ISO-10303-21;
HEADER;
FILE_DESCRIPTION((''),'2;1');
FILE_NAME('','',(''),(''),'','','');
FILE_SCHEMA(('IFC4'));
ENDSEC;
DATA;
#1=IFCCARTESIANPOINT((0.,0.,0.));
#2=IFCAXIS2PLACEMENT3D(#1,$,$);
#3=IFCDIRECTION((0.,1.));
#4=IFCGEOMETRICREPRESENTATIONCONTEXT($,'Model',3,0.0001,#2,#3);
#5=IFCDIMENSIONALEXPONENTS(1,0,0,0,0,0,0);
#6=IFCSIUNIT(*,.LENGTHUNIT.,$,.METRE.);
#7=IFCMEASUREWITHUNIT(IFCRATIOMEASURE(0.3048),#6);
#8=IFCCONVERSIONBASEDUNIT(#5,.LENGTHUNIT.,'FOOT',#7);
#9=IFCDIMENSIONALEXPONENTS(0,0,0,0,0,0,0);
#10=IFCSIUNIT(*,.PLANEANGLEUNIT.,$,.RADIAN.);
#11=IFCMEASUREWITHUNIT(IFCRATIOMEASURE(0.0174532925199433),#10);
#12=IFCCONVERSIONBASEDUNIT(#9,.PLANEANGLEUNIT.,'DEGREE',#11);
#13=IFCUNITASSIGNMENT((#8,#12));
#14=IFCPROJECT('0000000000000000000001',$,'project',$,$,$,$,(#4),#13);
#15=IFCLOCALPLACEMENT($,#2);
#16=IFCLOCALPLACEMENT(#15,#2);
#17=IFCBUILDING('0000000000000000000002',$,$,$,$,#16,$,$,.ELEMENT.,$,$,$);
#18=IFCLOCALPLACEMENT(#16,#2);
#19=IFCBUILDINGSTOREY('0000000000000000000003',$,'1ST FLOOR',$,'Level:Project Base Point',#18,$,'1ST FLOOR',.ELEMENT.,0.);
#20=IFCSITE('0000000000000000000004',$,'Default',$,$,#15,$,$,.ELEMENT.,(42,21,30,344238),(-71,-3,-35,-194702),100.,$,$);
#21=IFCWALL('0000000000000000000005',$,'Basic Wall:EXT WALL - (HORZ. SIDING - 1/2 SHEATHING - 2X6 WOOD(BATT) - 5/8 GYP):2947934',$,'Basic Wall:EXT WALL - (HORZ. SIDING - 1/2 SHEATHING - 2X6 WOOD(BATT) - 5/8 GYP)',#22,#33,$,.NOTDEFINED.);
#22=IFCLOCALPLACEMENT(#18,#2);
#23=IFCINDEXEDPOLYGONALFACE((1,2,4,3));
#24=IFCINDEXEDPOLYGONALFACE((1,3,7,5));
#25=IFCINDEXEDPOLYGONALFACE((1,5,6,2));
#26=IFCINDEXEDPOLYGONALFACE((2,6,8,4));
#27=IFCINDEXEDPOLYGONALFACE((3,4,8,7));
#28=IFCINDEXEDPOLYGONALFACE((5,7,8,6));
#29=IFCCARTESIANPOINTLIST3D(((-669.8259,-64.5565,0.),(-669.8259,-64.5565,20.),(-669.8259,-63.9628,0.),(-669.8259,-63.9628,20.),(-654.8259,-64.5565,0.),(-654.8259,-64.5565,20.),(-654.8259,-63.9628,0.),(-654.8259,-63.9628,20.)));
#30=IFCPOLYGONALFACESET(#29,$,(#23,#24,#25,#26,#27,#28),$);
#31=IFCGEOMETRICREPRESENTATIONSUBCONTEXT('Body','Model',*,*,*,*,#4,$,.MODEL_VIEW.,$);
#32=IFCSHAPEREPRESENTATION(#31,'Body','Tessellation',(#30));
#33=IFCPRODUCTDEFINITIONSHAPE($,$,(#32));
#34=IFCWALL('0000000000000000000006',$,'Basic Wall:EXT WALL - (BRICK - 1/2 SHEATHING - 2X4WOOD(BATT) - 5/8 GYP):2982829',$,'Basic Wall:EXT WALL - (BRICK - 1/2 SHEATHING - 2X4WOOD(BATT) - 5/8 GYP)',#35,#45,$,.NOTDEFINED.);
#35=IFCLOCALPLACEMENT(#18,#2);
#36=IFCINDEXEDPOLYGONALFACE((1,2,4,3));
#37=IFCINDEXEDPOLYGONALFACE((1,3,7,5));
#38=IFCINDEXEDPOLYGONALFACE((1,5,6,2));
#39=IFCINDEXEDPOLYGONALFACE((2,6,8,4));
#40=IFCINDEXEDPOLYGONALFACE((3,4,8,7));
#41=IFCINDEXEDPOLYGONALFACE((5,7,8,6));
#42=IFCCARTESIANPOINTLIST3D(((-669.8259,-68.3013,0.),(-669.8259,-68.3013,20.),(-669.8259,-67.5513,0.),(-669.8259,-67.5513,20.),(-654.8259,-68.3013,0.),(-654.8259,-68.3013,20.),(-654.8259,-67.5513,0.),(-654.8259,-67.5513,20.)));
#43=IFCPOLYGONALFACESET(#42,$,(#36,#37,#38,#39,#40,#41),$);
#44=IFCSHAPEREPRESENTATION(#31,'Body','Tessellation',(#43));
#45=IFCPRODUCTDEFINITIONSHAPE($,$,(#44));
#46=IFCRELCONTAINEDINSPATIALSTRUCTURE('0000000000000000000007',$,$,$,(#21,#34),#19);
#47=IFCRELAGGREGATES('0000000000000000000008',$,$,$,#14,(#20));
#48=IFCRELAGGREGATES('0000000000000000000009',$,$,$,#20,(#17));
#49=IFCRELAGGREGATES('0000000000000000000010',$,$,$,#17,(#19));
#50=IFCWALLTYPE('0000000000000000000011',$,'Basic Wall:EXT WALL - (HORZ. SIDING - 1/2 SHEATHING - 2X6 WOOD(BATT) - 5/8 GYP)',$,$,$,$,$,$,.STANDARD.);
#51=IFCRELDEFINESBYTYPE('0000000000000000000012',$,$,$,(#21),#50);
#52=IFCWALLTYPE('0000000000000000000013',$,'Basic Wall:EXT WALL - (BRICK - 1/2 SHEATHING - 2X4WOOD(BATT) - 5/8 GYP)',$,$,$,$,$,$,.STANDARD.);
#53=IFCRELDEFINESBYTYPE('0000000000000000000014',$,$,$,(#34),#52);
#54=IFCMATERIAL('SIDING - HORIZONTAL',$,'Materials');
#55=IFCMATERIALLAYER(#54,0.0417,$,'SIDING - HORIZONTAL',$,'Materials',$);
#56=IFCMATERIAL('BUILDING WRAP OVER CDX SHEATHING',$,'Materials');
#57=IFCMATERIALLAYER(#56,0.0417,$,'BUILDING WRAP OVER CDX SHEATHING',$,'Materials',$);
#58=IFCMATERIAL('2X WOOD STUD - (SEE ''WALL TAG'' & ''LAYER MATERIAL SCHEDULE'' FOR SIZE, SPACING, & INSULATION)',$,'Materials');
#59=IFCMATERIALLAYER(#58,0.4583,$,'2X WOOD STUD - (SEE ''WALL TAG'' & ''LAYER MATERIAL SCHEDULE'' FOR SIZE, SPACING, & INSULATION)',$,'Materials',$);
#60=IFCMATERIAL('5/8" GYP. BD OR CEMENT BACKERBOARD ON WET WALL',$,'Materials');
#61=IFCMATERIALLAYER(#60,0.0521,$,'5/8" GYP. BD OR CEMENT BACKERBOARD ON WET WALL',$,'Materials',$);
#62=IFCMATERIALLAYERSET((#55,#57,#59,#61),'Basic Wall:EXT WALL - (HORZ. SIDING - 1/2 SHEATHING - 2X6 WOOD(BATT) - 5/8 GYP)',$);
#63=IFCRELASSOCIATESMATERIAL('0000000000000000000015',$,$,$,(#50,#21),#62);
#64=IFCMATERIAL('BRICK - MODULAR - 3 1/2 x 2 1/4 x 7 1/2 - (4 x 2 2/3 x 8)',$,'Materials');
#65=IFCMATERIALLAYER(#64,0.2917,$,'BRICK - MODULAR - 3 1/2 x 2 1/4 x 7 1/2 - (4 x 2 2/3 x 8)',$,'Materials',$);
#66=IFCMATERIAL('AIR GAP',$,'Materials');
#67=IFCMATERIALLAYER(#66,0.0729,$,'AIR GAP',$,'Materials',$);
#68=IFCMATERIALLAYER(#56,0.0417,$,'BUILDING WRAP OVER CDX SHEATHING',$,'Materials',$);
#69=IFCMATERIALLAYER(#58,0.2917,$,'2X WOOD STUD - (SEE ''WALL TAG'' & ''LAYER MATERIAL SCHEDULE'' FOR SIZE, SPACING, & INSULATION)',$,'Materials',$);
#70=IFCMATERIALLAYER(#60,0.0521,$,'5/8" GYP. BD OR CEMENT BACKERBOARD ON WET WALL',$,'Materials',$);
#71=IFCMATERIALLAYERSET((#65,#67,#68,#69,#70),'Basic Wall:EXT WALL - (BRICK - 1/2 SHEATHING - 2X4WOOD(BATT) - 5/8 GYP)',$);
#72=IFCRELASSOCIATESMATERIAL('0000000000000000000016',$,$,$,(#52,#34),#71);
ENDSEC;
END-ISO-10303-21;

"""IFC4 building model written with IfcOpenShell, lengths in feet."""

from ifc_helpers import new_model, entity, si_unit, converted_unit, direction, frame, frame_2d, origin, place, context, subcontext, project, spatial, rectangle, extrude, material, layer, layer_set, layer_usage, type_object, element, save


model = new_model("IFC4")

# Units and contexts
model_context = context("Model", 3, precision=0.0001, world=origin(), true_north=direction((0.0, 1.0)))
body_context = subcontext(model_context, "Body", "Model", "MODEL_VIEW")
ifc_project = project(units=[converted_unit("LENGTHUNIT", "FOOT", entity("IfcRatioMeasure", 0.3048), si_unit("LENGTHUNIT", "METRE"), dimensions=[1, 0, 0, 0, 0, 0, 0]), converted_unit("PLANEANGLEUNIT", "DEGREE", entity("IfcRatioMeasure", 0.0174532925199433), si_unit("PLANEANGLEUNIT", "RADIAN"), dimensions=[0, 0, 0, 0, 0, 0, 0])], contexts=[model_context])

# Site, building, storey
site_placement = place(None, origin())
site = spatial("IfcSite", under=ifc_project, at=site_placement, Name="Default", CompositionType="ELEMENT", RefLatitude=(42, 21, 30, 344238), RefLongitude=(-71, -3, -35, -194702), RefElevation=100.0)
building_placement = place(site_placement, origin())
building = spatial("IfcBuilding", under=site, at=building_placement, CompositionType="ELEMENT")
storey_placement = place(building_placement, origin())
storey = spatial("IfcBuildingStorey", under=building, at=storey_placement, Name="1ST FLOOR", ObjectType="Level:Project Base Point", LongName="1ST FLOOR", CompositionType="ELEMENT", Elevation=0.0)

# Walls
ifc_material_1 = material(Name="SIDING - HORIZONTAL", Category="Materials")
ifc_material_2 = material(Name="BUILDING WRAP OVER CDX SHEATHING", Category="Materials")
ifc_material_3 = material(Name="2X WOOD STUD - (SEE 'WALL TAG' & 'LAYER MATERIAL SCHEDULE' FOR SIZE, SPACING, & INSULATION)", Category="Materials")
ifc_material_4 = material(Name="5/8\" GYP. BD OR CEMENT BACKERBOARD ON WET WALL", Category="Materials")
ifc_layer_1 = layer(ifc_material_1, 0.0417, Name="SIDING - HORIZONTAL", Category="Materials")
ifc_layer_2 = layer(ifc_material_2, 0.0417, Name="BUILDING WRAP OVER CDX SHEATHING", Category="Materials")
ifc_layer_3 = layer(ifc_material_3, 0.4583, Name="2X WOOD STUD - (SEE 'WALL TAG' & 'LAYER MATERIAL SCHEDULE' FOR SIZE, SPACING, & INSULATION)", Category="Materials")
ifc_layer_4 = layer(ifc_material_4, 0.0521, Name="5/8\" GYP. BD OR CEMENT BACKERBOARD ON WET WALL", Category="Materials")
ifc_layer_set_1 = layer_set([ifc_layer_1, ifc_layer_2, ifc_layer_3, ifc_layer_4], Name="Basic Wall:EXT WALL - (HORZ. SIDING - 1/2 SHEATHING - 2X6 WOOD(BATT) - 5/8 GYP)")
ifc_layer_usage_1 = layer_usage(ifc_layer_set_1, "AXIS2", "NEGATIVE", 0.2969)
wall_type_1 = type_object("IfcWallType", Name="Basic Wall:EXT WALL - (HORZ. SIDING - 1/2 SHEATHING - 2X6 WOOD(BATT) - 5/8 GYP)", PredefinedType="STANDARD", material=ifc_layer_set_1)
wall_1_placement = place(storey_placement, frame((-669.8259, -64.2596, 0.0)))
element("IfcWall", 1, at=wall_1_placement, inside=storey, type_object=wall_type_1, material=ifc_layer_usage_1, Name="Basic Wall:EXT WALL - (HORZ. SIDING - 1/2 SHEATHING - 2X6 WOOD(BATT) - 5/8 GYP):2947934", ObjectType="Basic Wall:EXT WALL - (HORZ. SIDING - 1/2 SHEATHING - 2X6 WOOD(BATT) - 5/8 GYP)", PredefinedType="NOTDEFINED", context=body_context, shape_type="SweptSolid", body=[
    extrude(rectangle(XDim=15.0, YDim=0.5938, at=frame_2d((7.5, 0.0), x_axis=(-1.0, 0.0))), origin(), (0.0, 0.0, 1.0), 20.0),
])
ifc_material_5 = material(Name="BRICK - MODULAR - 3 1/2 x 2 1/4 x 7 1/2 - (4 x 2 2/3 x 8)", Category="Materials")
ifc_layer_5 = layer(ifc_material_5, 0.2917, Name="BRICK - MODULAR - 3 1/2 x 2 1/4 x 7 1/2 - (4 x 2 2/3 x 8)", Category="Materials")
ifc_material_6 = material(Name="AIR GAP", Category="Materials")
ifc_layer_6 = layer(ifc_material_6, 0.0729, Name="AIR GAP", Category="Materials")
ifc_layer_7 = layer(ifc_material_2, 0.0417, Name="BUILDING WRAP OVER CDX SHEATHING", Category="Materials")
ifc_layer_8 = layer(ifc_material_3, 0.2917, Name="2X WOOD STUD - (SEE 'WALL TAG' & 'LAYER MATERIAL SCHEDULE' FOR SIZE, SPACING, & INSULATION)", Category="Materials")
ifc_layer_9 = layer(ifc_material_4, 0.0521, Name="5/8\" GYP. BD OR CEMENT BACKERBOARD ON WET WALL", Category="Materials")
ifc_layer_set_2 = layer_set([ifc_layer_5, ifc_layer_6, ifc_layer_7, ifc_layer_8, ifc_layer_9], Name="Basic Wall:EXT WALL - (BRICK - 1/2 SHEATHING - 2X4WOOD(BATT) - 5/8 GYP)")
ifc_layer_usage_2 = layer_usage(ifc_layer_set_2, "AXIS2", "NEGATIVE", 0.375)
wall_type_2 = type_object("IfcWallType", Name="Basic Wall:EXT WALL - (BRICK - 1/2 SHEATHING - 2X4WOOD(BATT) - 5/8 GYP)", PredefinedType="STANDARD", material=ifc_layer_set_2)
wall_2_placement = place(storey_placement, frame((-669.8259, -67.9263, 0.0)))
element("IfcWall", 2, at=wall_2_placement, inside=storey, type_object=wall_type_2, material=ifc_layer_usage_2, Name="Basic Wall:EXT WALL - (BRICK - 1/2 SHEATHING - 2X4WOOD(BATT) - 5/8 GYP):2982829", ObjectType="Basic Wall:EXT WALL - (BRICK - 1/2 SHEATHING - 2X4WOOD(BATT) - 5/8 GYP)", PredefinedType="NOTDEFINED", context=body_context, shape_type="SweptSolid", body=[
    extrude(rectangle(XDim=15.0, YDim=0.75, at=frame_2d((7.5, 0.0), x_axis=(-1.0, 0.0))), origin(), (0.0, 0.0, 1.0), 20.0),
])

save(model, "model.ifc")
